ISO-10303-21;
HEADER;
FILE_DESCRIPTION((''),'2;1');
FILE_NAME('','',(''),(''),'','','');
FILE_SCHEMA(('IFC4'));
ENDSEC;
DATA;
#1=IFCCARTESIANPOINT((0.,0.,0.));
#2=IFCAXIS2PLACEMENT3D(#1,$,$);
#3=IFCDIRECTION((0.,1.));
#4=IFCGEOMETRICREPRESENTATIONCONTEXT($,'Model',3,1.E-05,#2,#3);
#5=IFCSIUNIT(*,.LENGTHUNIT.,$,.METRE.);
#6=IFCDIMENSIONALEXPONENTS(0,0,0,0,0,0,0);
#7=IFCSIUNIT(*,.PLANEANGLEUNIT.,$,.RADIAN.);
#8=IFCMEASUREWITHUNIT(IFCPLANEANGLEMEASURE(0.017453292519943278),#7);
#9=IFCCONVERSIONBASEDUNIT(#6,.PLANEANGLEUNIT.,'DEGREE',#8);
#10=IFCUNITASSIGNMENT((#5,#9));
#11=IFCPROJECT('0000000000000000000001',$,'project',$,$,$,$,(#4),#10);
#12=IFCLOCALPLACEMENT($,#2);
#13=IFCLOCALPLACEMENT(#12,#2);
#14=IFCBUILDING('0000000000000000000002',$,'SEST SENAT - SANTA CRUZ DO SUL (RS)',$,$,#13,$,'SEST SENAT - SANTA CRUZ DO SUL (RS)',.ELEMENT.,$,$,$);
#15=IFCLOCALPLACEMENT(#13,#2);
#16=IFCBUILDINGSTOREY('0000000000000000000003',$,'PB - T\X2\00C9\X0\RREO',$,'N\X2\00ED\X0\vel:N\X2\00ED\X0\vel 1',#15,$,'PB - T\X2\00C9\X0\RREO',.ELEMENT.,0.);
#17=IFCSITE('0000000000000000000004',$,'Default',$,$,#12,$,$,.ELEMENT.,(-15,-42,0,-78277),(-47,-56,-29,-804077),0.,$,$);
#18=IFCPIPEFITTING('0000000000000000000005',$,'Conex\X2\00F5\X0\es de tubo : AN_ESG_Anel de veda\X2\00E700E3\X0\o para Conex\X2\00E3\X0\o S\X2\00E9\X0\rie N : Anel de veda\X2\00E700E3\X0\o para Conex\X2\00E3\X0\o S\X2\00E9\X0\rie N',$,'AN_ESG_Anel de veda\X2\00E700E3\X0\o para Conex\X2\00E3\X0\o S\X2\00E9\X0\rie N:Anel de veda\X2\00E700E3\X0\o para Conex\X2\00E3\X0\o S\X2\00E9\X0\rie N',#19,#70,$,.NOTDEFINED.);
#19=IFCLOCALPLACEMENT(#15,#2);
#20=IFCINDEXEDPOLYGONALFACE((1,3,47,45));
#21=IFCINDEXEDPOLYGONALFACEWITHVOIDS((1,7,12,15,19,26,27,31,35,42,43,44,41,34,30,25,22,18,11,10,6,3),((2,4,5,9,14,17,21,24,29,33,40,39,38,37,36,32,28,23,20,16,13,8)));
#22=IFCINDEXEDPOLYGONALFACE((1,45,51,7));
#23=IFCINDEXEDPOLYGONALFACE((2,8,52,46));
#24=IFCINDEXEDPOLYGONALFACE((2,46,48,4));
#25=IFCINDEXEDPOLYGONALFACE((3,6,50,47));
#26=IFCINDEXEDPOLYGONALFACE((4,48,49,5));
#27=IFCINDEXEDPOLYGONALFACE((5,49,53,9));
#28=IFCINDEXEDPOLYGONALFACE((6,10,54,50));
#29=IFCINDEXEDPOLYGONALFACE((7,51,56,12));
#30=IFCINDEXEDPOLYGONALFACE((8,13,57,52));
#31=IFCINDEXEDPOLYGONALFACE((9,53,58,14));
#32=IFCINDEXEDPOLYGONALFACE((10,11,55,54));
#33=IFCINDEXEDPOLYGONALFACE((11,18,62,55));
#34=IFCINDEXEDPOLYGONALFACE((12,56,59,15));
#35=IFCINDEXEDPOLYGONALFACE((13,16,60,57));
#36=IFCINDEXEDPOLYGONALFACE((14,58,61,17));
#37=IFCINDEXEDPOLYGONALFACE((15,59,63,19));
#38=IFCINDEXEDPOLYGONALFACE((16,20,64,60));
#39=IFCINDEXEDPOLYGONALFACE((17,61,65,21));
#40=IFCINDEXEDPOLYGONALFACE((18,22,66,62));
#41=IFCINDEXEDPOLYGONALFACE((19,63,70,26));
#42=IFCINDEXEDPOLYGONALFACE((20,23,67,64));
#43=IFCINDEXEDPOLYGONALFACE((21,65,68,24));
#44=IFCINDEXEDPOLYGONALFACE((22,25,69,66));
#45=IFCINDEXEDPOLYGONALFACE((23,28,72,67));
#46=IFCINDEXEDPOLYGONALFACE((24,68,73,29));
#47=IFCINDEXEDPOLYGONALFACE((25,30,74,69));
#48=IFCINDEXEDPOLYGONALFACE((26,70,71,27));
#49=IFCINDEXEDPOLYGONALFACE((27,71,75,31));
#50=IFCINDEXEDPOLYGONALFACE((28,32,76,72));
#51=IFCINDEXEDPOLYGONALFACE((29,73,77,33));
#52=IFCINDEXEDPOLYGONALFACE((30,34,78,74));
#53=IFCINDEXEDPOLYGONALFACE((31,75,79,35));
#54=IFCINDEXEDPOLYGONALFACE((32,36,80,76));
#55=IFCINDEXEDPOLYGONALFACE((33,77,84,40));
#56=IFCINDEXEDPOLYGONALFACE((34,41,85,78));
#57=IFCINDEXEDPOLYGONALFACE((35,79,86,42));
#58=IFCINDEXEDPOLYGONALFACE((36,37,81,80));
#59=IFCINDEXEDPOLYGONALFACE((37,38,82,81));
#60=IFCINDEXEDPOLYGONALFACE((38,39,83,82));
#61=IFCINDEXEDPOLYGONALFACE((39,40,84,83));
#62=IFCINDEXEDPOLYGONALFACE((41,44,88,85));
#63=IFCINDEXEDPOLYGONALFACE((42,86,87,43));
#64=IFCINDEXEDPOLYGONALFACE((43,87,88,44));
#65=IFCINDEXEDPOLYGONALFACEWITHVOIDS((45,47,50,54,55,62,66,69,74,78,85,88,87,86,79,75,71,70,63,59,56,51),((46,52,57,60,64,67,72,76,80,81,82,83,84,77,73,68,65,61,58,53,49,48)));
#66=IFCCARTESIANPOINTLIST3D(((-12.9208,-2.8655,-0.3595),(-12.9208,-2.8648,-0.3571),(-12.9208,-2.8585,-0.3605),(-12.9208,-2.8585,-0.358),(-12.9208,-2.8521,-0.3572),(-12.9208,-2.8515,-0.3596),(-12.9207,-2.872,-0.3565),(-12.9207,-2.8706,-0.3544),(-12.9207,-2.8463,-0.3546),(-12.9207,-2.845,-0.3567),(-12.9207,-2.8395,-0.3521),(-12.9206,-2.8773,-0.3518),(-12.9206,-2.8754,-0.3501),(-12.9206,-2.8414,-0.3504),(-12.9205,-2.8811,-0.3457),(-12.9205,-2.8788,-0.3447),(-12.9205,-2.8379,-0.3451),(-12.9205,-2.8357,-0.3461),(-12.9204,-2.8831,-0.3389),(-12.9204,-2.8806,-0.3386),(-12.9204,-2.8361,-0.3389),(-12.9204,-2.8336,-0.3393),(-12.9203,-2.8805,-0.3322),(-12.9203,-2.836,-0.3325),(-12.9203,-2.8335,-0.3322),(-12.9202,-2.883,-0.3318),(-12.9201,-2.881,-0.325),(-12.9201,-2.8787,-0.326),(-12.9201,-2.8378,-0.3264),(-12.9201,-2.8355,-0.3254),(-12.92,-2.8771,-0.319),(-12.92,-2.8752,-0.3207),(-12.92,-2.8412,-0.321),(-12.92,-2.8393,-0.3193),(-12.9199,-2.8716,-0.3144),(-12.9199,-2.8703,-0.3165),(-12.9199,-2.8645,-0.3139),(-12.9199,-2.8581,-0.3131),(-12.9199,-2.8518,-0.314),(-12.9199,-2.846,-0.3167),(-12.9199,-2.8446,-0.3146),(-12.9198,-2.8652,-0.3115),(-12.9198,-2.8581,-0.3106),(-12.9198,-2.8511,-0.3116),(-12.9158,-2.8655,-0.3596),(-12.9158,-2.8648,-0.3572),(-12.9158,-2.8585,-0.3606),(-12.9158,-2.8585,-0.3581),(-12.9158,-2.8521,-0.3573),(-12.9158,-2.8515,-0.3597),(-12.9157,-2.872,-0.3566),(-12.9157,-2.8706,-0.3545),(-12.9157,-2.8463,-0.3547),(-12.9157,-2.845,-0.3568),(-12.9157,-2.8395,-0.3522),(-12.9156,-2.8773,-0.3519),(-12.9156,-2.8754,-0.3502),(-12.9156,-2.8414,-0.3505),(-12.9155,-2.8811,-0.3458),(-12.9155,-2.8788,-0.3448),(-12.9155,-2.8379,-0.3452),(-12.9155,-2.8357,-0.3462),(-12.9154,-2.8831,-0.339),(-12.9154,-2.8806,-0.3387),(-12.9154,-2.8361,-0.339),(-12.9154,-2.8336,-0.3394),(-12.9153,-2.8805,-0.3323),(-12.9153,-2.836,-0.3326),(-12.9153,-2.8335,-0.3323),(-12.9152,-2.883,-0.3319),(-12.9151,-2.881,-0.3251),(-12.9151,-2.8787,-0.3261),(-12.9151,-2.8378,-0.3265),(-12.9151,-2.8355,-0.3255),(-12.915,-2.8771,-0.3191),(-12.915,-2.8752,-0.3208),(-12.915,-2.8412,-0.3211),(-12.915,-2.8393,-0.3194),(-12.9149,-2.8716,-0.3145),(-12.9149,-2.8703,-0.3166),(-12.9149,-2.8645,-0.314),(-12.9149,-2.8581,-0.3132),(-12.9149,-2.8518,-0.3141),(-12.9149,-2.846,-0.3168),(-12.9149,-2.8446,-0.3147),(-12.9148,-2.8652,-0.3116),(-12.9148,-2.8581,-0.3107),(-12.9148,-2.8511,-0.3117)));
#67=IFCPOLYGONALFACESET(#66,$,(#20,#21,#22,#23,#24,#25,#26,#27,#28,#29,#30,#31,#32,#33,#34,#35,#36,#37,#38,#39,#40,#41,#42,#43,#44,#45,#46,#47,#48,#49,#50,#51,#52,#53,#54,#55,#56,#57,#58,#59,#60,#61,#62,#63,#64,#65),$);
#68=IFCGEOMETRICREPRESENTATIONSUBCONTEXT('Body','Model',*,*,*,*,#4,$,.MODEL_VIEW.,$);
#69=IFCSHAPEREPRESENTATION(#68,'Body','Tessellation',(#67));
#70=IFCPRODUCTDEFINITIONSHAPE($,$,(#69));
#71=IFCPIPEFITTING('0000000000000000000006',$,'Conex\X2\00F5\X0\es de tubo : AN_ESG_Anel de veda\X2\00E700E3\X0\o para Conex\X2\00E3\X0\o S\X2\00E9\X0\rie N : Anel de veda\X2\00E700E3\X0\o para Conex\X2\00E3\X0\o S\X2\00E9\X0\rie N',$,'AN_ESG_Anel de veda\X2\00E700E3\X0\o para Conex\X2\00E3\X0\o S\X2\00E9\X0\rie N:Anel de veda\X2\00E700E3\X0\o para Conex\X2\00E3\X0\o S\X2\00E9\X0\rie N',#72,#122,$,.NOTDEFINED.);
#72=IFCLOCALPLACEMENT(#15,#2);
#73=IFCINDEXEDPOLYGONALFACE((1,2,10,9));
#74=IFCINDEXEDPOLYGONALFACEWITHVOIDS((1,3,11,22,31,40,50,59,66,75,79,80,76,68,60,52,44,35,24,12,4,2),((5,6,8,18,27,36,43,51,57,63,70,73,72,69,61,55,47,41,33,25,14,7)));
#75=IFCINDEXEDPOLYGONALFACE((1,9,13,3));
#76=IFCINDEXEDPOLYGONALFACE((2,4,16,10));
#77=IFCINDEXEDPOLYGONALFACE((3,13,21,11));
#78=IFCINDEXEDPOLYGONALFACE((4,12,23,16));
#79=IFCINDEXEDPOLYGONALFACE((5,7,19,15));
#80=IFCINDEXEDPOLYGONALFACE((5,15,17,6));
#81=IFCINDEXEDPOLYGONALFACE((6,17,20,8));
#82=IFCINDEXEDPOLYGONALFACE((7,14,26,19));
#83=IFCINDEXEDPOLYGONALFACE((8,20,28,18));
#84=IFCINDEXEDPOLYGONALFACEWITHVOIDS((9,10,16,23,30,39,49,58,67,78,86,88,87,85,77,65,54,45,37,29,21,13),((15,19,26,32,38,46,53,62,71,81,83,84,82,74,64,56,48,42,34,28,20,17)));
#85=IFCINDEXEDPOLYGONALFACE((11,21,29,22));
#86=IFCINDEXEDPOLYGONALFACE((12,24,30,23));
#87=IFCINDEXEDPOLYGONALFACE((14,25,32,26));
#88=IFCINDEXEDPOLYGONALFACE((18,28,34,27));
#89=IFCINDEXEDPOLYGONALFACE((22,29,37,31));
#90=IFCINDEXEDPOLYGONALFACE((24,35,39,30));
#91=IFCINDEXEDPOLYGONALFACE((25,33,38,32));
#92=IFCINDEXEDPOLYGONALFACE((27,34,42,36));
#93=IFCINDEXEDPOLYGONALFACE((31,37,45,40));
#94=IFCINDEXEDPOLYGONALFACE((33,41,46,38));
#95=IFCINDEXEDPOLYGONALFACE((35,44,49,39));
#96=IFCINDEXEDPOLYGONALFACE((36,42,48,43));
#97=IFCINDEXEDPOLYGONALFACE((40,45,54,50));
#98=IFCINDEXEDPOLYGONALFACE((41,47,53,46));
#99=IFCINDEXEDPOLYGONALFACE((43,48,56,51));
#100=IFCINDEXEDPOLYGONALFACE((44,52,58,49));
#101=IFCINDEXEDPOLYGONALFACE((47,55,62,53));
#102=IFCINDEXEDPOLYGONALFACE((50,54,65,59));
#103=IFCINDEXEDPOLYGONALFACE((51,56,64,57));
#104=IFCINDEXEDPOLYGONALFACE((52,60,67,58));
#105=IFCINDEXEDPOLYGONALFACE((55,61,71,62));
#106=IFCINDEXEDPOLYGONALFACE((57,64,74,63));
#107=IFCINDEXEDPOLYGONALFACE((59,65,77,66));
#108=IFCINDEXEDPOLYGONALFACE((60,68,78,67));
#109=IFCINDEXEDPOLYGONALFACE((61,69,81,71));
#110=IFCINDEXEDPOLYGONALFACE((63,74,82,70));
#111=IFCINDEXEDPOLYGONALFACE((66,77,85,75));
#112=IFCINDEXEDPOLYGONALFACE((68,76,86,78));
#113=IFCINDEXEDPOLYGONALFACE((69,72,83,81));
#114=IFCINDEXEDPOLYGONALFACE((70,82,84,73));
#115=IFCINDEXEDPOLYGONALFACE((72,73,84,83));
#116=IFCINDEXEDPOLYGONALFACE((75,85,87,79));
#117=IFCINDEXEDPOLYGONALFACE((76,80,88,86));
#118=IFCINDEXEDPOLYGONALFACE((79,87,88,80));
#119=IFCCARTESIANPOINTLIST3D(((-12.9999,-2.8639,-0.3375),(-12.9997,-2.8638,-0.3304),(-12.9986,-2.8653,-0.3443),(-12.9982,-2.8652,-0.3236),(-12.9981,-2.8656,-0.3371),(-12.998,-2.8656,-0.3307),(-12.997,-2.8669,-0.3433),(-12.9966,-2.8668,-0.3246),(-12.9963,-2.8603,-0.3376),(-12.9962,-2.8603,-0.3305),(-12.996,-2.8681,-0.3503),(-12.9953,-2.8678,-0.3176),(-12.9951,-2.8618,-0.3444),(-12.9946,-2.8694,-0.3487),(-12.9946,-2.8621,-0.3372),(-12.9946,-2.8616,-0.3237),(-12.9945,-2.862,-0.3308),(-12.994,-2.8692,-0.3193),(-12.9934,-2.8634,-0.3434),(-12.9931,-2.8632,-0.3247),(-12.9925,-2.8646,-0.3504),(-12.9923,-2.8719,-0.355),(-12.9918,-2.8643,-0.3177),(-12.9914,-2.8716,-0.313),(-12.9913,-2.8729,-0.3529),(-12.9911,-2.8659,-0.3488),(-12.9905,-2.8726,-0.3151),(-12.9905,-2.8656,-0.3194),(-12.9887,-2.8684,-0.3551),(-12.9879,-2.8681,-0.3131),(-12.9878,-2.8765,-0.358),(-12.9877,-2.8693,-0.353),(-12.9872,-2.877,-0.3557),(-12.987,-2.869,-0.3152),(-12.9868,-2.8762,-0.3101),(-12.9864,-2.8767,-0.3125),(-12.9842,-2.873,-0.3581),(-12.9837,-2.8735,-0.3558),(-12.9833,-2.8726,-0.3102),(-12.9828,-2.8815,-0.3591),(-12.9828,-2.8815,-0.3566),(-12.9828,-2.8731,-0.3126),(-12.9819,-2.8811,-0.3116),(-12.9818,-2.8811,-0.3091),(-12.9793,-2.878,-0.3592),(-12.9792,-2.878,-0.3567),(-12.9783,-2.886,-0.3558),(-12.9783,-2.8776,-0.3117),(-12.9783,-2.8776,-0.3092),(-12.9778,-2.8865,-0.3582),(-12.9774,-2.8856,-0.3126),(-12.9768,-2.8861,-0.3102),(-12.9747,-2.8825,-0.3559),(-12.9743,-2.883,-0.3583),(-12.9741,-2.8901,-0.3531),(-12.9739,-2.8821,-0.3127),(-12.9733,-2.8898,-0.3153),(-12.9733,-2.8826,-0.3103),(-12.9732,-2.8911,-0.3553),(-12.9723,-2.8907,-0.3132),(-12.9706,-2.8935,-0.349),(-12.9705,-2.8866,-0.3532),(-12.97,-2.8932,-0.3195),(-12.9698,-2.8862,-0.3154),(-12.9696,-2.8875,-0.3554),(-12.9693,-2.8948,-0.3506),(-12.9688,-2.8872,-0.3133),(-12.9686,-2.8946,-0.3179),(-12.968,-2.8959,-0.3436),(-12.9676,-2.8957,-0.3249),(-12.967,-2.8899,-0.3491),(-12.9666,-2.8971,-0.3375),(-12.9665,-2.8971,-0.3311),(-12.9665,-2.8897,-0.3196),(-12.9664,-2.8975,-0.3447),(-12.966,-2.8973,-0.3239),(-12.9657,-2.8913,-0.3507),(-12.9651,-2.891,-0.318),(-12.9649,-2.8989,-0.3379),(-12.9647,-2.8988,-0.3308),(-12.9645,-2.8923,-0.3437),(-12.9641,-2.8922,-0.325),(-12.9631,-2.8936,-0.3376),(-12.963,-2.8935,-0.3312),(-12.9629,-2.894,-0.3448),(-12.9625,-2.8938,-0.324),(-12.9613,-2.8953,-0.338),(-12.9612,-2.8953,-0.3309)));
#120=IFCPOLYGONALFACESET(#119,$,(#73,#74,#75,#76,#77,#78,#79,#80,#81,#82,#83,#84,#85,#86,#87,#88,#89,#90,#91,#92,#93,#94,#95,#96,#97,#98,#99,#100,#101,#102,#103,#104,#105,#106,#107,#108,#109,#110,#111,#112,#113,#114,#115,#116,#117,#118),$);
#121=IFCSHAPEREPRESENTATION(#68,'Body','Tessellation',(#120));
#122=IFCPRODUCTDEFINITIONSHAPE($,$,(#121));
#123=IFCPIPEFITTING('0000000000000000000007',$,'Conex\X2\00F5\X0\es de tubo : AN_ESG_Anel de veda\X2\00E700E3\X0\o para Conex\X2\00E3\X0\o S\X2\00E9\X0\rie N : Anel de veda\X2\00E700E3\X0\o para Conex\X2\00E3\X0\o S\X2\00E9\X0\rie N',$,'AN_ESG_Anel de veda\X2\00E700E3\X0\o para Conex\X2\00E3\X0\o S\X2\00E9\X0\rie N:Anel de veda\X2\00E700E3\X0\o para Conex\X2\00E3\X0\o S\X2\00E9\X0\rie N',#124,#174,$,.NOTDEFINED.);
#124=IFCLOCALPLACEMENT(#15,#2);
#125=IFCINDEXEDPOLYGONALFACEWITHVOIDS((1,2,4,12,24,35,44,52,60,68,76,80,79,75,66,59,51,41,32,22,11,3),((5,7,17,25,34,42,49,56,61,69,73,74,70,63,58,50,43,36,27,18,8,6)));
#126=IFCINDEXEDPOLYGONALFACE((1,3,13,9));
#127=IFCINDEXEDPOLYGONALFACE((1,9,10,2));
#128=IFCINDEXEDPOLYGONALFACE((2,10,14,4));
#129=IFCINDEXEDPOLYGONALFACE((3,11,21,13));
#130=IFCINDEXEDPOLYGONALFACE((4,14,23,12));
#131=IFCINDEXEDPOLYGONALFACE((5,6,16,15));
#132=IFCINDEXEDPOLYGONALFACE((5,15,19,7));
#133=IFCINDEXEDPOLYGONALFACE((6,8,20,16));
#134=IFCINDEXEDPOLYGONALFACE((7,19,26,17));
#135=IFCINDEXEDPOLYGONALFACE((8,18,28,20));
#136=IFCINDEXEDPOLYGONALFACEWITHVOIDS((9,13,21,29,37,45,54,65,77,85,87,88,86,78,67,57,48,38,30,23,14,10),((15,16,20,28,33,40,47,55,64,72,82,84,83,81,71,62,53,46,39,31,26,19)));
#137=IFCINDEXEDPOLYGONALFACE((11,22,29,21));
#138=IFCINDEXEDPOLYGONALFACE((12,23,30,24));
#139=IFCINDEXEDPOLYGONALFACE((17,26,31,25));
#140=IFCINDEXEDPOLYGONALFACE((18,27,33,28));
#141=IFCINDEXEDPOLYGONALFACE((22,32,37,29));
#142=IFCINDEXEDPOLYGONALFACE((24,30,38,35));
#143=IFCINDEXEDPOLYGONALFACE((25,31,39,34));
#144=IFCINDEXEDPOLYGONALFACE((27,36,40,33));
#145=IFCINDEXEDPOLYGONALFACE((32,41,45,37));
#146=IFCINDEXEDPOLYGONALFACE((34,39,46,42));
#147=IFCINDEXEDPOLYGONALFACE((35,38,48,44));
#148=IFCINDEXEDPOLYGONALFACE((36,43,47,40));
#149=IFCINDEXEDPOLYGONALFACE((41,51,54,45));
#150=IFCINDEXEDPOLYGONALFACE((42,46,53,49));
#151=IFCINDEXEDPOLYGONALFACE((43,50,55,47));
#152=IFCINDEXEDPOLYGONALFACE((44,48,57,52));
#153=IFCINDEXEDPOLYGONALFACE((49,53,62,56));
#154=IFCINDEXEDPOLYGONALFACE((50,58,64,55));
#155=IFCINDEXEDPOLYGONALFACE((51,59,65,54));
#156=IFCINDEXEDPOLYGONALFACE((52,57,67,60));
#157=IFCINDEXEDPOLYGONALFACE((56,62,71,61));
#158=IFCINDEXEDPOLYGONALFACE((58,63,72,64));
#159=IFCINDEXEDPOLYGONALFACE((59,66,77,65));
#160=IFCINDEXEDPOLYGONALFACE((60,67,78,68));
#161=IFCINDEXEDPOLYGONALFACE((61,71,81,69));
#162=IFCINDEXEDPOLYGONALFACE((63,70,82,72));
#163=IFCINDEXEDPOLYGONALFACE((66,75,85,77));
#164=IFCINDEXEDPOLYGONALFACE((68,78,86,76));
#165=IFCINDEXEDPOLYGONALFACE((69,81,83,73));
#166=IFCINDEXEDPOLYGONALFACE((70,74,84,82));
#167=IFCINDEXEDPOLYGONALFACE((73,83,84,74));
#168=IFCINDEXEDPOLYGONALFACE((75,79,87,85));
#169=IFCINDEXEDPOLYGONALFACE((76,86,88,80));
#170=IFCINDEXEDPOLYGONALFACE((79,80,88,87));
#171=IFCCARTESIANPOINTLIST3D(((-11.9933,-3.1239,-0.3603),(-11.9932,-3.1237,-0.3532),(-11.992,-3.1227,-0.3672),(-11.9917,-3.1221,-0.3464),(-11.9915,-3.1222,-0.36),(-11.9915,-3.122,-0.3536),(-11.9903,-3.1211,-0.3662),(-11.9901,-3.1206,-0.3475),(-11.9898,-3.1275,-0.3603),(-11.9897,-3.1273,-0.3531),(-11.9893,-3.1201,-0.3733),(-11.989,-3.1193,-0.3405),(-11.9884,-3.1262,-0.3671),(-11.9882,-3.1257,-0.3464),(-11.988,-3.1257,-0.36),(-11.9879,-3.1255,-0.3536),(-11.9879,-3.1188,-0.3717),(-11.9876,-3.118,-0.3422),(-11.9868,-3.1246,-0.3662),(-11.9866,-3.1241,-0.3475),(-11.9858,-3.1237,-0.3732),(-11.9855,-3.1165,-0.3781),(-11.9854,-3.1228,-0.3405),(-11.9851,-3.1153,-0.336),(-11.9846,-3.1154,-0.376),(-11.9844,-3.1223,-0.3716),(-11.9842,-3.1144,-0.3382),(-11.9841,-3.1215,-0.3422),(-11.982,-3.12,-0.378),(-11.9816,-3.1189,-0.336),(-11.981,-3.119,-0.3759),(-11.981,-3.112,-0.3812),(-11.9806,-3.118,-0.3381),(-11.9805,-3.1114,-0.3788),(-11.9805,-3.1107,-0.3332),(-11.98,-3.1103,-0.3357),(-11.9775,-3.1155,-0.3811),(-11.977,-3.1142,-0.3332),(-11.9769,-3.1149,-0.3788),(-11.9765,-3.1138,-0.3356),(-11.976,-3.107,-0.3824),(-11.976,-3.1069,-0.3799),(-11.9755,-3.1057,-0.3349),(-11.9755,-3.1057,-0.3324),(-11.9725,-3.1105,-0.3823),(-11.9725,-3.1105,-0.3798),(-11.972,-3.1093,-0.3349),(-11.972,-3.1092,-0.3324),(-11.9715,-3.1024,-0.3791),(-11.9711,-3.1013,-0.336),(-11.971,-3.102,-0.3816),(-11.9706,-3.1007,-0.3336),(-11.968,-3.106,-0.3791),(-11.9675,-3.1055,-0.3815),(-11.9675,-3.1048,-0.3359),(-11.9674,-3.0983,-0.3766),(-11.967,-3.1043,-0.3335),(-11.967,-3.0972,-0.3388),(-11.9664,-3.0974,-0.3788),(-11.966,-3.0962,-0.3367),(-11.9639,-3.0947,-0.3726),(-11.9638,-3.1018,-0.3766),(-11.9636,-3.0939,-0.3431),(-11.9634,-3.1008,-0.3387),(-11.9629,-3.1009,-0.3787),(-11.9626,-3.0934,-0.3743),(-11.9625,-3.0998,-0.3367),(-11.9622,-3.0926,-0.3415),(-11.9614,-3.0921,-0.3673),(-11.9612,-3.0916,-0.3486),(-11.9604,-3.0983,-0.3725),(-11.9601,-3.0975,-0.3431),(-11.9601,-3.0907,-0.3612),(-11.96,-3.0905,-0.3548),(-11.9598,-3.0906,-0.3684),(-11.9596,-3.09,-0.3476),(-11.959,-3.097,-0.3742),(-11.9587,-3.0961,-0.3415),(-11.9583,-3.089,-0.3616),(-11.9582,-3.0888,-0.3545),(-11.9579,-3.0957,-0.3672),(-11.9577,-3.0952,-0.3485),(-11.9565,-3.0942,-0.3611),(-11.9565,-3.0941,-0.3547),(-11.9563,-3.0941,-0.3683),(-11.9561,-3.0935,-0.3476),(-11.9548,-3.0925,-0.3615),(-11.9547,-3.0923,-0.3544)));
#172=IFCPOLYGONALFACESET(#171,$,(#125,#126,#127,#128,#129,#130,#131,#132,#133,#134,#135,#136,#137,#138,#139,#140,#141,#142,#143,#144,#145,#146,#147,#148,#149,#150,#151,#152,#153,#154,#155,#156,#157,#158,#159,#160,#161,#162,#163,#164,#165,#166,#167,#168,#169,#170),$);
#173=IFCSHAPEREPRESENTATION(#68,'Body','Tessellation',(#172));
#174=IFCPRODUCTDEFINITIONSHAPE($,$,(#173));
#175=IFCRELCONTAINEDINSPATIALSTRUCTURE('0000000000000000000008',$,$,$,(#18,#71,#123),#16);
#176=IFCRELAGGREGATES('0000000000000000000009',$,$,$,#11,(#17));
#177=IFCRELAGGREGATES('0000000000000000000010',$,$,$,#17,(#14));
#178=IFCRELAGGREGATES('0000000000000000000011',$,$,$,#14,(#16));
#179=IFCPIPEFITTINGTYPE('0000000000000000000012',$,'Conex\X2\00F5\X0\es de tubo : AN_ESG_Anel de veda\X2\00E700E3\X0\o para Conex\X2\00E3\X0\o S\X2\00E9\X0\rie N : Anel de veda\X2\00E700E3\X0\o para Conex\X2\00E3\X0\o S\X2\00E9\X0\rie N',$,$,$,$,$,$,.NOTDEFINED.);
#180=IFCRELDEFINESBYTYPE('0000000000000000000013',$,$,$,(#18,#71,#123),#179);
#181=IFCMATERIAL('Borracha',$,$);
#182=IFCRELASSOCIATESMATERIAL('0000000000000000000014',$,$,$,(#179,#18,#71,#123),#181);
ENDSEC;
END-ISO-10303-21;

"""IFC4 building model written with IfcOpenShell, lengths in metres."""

from ifc_helpers import new_model, entity, si_unit, converted_unit, direction, frame, origin, place, context, subcontext, project, spatial, arc, indexed_curve, outline, extrude, source, transform, mapped, material, type_object, type_shapes, element, save


model = new_model("IFC4")

# Units and contexts
model_context = context("Model", 3, precision=1e-05, world=origin(), true_north=direction((0.0, 1.0)))
body_context = subcontext(model_context, "Body", "Model", "MODEL_VIEW")
ifc_project = project(units=[si_unit("LENGTHUNIT", "METRE"), converted_unit("PLANEANGLEUNIT", "DEGREE", entity("IfcPlaneAngleMeasure", 0.017453292519943278), si_unit("PLANEANGLEUNIT", "RADIAN"), dimensions=[0, 0, 0, 0, 0, 0, 0])], contexts=[model_context])

# Site, building, storey
site_placement = place(None, origin())
site = spatial("IfcSite", under=ifc_project, at=site_placement, Name="Default", CompositionType="ELEMENT", RefLatitude=(-15, -42, 0, -78277), RefLongitude=(-47, -56, -29, -804077), RefElevation=0.0)
building_placement = place(site_placement, origin())
building = spatial("IfcBuilding", under=site, at=building_placement, Name="SEST SENAT - SANTA CRUZ DO SUL (RS)", LongName="SEST SENAT - SANTA CRUZ DO SUL (RS)", CompositionType="ELEMENT")
storey_placement = place(building_placement, origin())
storey = spatial("IfcBuildingStorey", under=building, at=storey_placement, Name="PB - TÉRREO", ObjectType="Nível:Nível 1", LongName="PB - TÉRREO", CompositionType="ELEMENT", Elevation=0.0)

# Pipe fittings
ifc_material = material(Name="Borracha")
pipe_fitting_type_1 = type_object("IfcPipeFittingType", Name="Conexões de tubo : AN_ESG_Anel de vedação para Conexão Série N : Anel de vedação para Conexão Série N", PredefinedType="NOTDEFINED", material=ifc_material)
shared_shape_1 = source(origin(), body_context, "Body", "SweptSolid", [
    extrude(outline(indexed_curve([(-0.025, 0.0), (0.0, -0.025), (0.025, 0.0), (0.0, 0.025)], segments=[arc(1, 2, 3), arc(3, 4, 1)], self_intersect=False), holes=[indexed_curve([(-0.0225, 0.0), (0.0, 0.0225), (0.0225, 0.0), (0.0, -0.0225)], segments=[arc(1, 2, 3), arc(3, 4, 1)], self_intersect=False)]), frame((0.0, 0.0, -0.005)), (0.0, 0.0, 1.0), 0.005),
])
type_shapes(pipe_fitting_type_1, [shared_shape_1])
for number, where, z_axis, x_axis, name in (
    (1, (-12.9153, -2.8583, -0.3357), (0.9998, 0.0, -0.019996), (0.019995, 0.008282, 0.999766), "Conexões de tubo : AN_ESG_Anel de vedação para Conexão Série N : Anel de vedação para Conexão Série N"),
    (2, (-12.9788, -2.8778, -0.3342), (0.706965, 0.706965, -0.019996), (0.019995, 0.008282, 0.999766), "Conexões de tubo : AN_ESG_Anel de vedação para Conexão Série N : Anel de vedação para Conexão Série N"),
    (3, (-11.9722, -3.1099, -0.3573), (0.707128, -0.706987, 0.011818), (0.009996, 0.026708, 0.999593), "Conexões de tubo : AN_ESG_Anel de vedação para Conexão Série N : Anel de vedação para Conexão Série N"),
):
    element("IfcPipeFitting", number, at=place(storey_placement, frame(where, z_axis=z_axis, x_axis=x_axis)), inside=storey, type_object=pipe_fitting_type_1, material=ifc_material, Name=name, ObjectType="AN_ESG_Anel de vedação para Conexão Série N:Anel de vedação para Conexão Série N", PredefinedType="NOTDEFINED", context=body_context, shape_type="MappedRepresentation", body=[
        mapped(shared_shape_1, transform((0.0, 0.0, 0.0), scale=1.0)),
    ])

save(model, "model.ifc")
